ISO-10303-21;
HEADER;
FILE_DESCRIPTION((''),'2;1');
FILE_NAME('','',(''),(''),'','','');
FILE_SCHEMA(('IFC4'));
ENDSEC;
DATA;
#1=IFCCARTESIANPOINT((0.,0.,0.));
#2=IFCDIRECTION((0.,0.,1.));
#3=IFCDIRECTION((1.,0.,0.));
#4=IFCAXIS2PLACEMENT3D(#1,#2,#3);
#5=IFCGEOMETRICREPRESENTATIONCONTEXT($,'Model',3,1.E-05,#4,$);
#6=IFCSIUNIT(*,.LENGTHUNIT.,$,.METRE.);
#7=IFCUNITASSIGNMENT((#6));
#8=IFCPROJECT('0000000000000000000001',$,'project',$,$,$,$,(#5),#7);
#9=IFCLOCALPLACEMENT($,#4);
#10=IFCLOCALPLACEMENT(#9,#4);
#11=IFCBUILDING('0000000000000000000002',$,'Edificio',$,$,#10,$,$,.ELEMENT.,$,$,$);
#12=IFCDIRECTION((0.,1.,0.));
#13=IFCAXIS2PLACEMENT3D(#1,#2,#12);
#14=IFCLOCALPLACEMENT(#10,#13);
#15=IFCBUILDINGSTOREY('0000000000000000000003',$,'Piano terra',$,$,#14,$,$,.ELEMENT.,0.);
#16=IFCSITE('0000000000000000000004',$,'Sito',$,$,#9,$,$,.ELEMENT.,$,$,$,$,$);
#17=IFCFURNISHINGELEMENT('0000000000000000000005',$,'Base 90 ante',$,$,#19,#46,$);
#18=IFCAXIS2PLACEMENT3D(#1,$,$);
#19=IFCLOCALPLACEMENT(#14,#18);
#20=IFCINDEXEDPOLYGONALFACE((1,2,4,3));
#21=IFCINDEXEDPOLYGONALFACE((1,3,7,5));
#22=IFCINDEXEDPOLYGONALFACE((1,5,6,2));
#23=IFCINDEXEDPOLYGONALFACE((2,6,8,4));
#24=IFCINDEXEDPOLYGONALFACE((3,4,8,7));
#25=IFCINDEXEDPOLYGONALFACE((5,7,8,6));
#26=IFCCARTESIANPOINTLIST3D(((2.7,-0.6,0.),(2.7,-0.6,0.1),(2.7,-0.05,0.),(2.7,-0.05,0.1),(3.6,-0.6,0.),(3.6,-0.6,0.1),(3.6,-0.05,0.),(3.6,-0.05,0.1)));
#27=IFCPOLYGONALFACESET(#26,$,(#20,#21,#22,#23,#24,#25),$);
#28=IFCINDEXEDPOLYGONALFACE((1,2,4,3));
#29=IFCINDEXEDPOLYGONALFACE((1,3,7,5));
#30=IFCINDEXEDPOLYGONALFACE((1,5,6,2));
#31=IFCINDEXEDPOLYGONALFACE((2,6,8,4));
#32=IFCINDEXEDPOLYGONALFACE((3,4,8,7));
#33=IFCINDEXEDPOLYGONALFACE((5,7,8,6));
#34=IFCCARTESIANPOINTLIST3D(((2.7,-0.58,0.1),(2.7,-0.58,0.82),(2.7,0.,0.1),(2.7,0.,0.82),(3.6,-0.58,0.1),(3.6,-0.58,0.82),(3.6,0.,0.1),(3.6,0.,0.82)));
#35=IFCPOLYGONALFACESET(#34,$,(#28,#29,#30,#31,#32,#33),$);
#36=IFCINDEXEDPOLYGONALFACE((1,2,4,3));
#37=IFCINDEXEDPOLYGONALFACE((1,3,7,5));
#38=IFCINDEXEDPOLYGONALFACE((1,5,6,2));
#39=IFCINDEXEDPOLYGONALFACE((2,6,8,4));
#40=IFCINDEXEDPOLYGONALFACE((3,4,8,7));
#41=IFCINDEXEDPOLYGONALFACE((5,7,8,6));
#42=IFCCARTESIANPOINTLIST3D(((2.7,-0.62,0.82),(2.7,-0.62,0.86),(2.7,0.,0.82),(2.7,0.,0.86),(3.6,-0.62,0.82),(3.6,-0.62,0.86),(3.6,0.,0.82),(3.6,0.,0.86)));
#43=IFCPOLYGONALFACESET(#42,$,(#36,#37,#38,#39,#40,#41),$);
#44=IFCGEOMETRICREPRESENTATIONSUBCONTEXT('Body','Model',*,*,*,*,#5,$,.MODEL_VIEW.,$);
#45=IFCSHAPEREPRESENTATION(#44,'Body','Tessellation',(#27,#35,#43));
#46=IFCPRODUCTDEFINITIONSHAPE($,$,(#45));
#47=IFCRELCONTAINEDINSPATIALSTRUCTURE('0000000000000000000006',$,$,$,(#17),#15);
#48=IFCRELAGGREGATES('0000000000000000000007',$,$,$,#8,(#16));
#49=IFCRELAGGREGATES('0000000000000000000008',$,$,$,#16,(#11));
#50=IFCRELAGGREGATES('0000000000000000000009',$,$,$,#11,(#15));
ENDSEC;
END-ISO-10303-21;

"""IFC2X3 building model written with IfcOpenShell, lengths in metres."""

from ifc_helpers import new_model, si_unit, frame, frame_2d, origin_with_axes, place, context, subcontext, project, spatial, rectangle, extrude, element, save


model = new_model("IFC2X3")

# Units and contexts
model_context = context("Model", 3, precision=1e-05, world=origin_with_axes())
body_context = subcontext(model_context, "Body", "Model", "MODEL_VIEW")
ifc_project = project(units=[si_unit("LENGTHUNIT", "METRE")], contexts=[model_context])

# Site, building, storey
site_placement = place(None, origin_with_axes())
site = spatial("IfcSite", under=ifc_project, at=site_placement, Name="Sito", CompositionType="ELEMENT")
building_placement = place(site_placement, origin_with_axes())
building = spatial("IfcBuilding", under=site, at=building_placement, Name="Edificio", CompositionType="ELEMENT")
storey_placement = place(building_placement, frame((0.0, 0.0, 0.0), z_axis=(0.0, 0.0, 1.0), x_axis=(0.0, 1.0, 0.0)))
storey = spatial("IfcBuildingStorey", under=building, at=storey_placement, Name="Piano terra", CompositionType="ELEMENT", Elevation=0.0)

# Furnishing element
furnishing_placement = place(storey_placement, origin_with_axes())
element("IfcFurnishingElement", 1, at=furnishing_placement, inside=storey, Name="Base 90 ante", context=body_context, shape_type="Brep", body=[
    extrude(rectangle(XDim=0.9, YDim=0.55, at=frame_2d((3.15, -0.325), x_axis=(1.0, 0.0))), origin_with_axes(), (0.0, 0.0, 1.0), 0.1),
    extrude(rectangle(XDim=0.9, YDim=0.58, at=frame_2d((3.15, -0.29), x_axis=(1.0, 0.0))), frame((0.0, 0.0, 0.1), z_axis=(0.0, 0.0, 1.0), x_axis=(1.0, 0.0, 0.0)), (0.0, 0.0, 1.0), 0.72),
    extrude(rectangle(XDim=0.9, YDim=0.62, at=frame_2d((3.15, -0.31), x_axis=(1.0, 0.0))), frame((0.0, 0.0, 0.82), z_axis=(0.0, 0.0, 1.0), x_axis=(1.0, 0.0, 0.0)), (0.0, 0.0, 1.0), 0.04),
])

save(model, "model.ifc")
